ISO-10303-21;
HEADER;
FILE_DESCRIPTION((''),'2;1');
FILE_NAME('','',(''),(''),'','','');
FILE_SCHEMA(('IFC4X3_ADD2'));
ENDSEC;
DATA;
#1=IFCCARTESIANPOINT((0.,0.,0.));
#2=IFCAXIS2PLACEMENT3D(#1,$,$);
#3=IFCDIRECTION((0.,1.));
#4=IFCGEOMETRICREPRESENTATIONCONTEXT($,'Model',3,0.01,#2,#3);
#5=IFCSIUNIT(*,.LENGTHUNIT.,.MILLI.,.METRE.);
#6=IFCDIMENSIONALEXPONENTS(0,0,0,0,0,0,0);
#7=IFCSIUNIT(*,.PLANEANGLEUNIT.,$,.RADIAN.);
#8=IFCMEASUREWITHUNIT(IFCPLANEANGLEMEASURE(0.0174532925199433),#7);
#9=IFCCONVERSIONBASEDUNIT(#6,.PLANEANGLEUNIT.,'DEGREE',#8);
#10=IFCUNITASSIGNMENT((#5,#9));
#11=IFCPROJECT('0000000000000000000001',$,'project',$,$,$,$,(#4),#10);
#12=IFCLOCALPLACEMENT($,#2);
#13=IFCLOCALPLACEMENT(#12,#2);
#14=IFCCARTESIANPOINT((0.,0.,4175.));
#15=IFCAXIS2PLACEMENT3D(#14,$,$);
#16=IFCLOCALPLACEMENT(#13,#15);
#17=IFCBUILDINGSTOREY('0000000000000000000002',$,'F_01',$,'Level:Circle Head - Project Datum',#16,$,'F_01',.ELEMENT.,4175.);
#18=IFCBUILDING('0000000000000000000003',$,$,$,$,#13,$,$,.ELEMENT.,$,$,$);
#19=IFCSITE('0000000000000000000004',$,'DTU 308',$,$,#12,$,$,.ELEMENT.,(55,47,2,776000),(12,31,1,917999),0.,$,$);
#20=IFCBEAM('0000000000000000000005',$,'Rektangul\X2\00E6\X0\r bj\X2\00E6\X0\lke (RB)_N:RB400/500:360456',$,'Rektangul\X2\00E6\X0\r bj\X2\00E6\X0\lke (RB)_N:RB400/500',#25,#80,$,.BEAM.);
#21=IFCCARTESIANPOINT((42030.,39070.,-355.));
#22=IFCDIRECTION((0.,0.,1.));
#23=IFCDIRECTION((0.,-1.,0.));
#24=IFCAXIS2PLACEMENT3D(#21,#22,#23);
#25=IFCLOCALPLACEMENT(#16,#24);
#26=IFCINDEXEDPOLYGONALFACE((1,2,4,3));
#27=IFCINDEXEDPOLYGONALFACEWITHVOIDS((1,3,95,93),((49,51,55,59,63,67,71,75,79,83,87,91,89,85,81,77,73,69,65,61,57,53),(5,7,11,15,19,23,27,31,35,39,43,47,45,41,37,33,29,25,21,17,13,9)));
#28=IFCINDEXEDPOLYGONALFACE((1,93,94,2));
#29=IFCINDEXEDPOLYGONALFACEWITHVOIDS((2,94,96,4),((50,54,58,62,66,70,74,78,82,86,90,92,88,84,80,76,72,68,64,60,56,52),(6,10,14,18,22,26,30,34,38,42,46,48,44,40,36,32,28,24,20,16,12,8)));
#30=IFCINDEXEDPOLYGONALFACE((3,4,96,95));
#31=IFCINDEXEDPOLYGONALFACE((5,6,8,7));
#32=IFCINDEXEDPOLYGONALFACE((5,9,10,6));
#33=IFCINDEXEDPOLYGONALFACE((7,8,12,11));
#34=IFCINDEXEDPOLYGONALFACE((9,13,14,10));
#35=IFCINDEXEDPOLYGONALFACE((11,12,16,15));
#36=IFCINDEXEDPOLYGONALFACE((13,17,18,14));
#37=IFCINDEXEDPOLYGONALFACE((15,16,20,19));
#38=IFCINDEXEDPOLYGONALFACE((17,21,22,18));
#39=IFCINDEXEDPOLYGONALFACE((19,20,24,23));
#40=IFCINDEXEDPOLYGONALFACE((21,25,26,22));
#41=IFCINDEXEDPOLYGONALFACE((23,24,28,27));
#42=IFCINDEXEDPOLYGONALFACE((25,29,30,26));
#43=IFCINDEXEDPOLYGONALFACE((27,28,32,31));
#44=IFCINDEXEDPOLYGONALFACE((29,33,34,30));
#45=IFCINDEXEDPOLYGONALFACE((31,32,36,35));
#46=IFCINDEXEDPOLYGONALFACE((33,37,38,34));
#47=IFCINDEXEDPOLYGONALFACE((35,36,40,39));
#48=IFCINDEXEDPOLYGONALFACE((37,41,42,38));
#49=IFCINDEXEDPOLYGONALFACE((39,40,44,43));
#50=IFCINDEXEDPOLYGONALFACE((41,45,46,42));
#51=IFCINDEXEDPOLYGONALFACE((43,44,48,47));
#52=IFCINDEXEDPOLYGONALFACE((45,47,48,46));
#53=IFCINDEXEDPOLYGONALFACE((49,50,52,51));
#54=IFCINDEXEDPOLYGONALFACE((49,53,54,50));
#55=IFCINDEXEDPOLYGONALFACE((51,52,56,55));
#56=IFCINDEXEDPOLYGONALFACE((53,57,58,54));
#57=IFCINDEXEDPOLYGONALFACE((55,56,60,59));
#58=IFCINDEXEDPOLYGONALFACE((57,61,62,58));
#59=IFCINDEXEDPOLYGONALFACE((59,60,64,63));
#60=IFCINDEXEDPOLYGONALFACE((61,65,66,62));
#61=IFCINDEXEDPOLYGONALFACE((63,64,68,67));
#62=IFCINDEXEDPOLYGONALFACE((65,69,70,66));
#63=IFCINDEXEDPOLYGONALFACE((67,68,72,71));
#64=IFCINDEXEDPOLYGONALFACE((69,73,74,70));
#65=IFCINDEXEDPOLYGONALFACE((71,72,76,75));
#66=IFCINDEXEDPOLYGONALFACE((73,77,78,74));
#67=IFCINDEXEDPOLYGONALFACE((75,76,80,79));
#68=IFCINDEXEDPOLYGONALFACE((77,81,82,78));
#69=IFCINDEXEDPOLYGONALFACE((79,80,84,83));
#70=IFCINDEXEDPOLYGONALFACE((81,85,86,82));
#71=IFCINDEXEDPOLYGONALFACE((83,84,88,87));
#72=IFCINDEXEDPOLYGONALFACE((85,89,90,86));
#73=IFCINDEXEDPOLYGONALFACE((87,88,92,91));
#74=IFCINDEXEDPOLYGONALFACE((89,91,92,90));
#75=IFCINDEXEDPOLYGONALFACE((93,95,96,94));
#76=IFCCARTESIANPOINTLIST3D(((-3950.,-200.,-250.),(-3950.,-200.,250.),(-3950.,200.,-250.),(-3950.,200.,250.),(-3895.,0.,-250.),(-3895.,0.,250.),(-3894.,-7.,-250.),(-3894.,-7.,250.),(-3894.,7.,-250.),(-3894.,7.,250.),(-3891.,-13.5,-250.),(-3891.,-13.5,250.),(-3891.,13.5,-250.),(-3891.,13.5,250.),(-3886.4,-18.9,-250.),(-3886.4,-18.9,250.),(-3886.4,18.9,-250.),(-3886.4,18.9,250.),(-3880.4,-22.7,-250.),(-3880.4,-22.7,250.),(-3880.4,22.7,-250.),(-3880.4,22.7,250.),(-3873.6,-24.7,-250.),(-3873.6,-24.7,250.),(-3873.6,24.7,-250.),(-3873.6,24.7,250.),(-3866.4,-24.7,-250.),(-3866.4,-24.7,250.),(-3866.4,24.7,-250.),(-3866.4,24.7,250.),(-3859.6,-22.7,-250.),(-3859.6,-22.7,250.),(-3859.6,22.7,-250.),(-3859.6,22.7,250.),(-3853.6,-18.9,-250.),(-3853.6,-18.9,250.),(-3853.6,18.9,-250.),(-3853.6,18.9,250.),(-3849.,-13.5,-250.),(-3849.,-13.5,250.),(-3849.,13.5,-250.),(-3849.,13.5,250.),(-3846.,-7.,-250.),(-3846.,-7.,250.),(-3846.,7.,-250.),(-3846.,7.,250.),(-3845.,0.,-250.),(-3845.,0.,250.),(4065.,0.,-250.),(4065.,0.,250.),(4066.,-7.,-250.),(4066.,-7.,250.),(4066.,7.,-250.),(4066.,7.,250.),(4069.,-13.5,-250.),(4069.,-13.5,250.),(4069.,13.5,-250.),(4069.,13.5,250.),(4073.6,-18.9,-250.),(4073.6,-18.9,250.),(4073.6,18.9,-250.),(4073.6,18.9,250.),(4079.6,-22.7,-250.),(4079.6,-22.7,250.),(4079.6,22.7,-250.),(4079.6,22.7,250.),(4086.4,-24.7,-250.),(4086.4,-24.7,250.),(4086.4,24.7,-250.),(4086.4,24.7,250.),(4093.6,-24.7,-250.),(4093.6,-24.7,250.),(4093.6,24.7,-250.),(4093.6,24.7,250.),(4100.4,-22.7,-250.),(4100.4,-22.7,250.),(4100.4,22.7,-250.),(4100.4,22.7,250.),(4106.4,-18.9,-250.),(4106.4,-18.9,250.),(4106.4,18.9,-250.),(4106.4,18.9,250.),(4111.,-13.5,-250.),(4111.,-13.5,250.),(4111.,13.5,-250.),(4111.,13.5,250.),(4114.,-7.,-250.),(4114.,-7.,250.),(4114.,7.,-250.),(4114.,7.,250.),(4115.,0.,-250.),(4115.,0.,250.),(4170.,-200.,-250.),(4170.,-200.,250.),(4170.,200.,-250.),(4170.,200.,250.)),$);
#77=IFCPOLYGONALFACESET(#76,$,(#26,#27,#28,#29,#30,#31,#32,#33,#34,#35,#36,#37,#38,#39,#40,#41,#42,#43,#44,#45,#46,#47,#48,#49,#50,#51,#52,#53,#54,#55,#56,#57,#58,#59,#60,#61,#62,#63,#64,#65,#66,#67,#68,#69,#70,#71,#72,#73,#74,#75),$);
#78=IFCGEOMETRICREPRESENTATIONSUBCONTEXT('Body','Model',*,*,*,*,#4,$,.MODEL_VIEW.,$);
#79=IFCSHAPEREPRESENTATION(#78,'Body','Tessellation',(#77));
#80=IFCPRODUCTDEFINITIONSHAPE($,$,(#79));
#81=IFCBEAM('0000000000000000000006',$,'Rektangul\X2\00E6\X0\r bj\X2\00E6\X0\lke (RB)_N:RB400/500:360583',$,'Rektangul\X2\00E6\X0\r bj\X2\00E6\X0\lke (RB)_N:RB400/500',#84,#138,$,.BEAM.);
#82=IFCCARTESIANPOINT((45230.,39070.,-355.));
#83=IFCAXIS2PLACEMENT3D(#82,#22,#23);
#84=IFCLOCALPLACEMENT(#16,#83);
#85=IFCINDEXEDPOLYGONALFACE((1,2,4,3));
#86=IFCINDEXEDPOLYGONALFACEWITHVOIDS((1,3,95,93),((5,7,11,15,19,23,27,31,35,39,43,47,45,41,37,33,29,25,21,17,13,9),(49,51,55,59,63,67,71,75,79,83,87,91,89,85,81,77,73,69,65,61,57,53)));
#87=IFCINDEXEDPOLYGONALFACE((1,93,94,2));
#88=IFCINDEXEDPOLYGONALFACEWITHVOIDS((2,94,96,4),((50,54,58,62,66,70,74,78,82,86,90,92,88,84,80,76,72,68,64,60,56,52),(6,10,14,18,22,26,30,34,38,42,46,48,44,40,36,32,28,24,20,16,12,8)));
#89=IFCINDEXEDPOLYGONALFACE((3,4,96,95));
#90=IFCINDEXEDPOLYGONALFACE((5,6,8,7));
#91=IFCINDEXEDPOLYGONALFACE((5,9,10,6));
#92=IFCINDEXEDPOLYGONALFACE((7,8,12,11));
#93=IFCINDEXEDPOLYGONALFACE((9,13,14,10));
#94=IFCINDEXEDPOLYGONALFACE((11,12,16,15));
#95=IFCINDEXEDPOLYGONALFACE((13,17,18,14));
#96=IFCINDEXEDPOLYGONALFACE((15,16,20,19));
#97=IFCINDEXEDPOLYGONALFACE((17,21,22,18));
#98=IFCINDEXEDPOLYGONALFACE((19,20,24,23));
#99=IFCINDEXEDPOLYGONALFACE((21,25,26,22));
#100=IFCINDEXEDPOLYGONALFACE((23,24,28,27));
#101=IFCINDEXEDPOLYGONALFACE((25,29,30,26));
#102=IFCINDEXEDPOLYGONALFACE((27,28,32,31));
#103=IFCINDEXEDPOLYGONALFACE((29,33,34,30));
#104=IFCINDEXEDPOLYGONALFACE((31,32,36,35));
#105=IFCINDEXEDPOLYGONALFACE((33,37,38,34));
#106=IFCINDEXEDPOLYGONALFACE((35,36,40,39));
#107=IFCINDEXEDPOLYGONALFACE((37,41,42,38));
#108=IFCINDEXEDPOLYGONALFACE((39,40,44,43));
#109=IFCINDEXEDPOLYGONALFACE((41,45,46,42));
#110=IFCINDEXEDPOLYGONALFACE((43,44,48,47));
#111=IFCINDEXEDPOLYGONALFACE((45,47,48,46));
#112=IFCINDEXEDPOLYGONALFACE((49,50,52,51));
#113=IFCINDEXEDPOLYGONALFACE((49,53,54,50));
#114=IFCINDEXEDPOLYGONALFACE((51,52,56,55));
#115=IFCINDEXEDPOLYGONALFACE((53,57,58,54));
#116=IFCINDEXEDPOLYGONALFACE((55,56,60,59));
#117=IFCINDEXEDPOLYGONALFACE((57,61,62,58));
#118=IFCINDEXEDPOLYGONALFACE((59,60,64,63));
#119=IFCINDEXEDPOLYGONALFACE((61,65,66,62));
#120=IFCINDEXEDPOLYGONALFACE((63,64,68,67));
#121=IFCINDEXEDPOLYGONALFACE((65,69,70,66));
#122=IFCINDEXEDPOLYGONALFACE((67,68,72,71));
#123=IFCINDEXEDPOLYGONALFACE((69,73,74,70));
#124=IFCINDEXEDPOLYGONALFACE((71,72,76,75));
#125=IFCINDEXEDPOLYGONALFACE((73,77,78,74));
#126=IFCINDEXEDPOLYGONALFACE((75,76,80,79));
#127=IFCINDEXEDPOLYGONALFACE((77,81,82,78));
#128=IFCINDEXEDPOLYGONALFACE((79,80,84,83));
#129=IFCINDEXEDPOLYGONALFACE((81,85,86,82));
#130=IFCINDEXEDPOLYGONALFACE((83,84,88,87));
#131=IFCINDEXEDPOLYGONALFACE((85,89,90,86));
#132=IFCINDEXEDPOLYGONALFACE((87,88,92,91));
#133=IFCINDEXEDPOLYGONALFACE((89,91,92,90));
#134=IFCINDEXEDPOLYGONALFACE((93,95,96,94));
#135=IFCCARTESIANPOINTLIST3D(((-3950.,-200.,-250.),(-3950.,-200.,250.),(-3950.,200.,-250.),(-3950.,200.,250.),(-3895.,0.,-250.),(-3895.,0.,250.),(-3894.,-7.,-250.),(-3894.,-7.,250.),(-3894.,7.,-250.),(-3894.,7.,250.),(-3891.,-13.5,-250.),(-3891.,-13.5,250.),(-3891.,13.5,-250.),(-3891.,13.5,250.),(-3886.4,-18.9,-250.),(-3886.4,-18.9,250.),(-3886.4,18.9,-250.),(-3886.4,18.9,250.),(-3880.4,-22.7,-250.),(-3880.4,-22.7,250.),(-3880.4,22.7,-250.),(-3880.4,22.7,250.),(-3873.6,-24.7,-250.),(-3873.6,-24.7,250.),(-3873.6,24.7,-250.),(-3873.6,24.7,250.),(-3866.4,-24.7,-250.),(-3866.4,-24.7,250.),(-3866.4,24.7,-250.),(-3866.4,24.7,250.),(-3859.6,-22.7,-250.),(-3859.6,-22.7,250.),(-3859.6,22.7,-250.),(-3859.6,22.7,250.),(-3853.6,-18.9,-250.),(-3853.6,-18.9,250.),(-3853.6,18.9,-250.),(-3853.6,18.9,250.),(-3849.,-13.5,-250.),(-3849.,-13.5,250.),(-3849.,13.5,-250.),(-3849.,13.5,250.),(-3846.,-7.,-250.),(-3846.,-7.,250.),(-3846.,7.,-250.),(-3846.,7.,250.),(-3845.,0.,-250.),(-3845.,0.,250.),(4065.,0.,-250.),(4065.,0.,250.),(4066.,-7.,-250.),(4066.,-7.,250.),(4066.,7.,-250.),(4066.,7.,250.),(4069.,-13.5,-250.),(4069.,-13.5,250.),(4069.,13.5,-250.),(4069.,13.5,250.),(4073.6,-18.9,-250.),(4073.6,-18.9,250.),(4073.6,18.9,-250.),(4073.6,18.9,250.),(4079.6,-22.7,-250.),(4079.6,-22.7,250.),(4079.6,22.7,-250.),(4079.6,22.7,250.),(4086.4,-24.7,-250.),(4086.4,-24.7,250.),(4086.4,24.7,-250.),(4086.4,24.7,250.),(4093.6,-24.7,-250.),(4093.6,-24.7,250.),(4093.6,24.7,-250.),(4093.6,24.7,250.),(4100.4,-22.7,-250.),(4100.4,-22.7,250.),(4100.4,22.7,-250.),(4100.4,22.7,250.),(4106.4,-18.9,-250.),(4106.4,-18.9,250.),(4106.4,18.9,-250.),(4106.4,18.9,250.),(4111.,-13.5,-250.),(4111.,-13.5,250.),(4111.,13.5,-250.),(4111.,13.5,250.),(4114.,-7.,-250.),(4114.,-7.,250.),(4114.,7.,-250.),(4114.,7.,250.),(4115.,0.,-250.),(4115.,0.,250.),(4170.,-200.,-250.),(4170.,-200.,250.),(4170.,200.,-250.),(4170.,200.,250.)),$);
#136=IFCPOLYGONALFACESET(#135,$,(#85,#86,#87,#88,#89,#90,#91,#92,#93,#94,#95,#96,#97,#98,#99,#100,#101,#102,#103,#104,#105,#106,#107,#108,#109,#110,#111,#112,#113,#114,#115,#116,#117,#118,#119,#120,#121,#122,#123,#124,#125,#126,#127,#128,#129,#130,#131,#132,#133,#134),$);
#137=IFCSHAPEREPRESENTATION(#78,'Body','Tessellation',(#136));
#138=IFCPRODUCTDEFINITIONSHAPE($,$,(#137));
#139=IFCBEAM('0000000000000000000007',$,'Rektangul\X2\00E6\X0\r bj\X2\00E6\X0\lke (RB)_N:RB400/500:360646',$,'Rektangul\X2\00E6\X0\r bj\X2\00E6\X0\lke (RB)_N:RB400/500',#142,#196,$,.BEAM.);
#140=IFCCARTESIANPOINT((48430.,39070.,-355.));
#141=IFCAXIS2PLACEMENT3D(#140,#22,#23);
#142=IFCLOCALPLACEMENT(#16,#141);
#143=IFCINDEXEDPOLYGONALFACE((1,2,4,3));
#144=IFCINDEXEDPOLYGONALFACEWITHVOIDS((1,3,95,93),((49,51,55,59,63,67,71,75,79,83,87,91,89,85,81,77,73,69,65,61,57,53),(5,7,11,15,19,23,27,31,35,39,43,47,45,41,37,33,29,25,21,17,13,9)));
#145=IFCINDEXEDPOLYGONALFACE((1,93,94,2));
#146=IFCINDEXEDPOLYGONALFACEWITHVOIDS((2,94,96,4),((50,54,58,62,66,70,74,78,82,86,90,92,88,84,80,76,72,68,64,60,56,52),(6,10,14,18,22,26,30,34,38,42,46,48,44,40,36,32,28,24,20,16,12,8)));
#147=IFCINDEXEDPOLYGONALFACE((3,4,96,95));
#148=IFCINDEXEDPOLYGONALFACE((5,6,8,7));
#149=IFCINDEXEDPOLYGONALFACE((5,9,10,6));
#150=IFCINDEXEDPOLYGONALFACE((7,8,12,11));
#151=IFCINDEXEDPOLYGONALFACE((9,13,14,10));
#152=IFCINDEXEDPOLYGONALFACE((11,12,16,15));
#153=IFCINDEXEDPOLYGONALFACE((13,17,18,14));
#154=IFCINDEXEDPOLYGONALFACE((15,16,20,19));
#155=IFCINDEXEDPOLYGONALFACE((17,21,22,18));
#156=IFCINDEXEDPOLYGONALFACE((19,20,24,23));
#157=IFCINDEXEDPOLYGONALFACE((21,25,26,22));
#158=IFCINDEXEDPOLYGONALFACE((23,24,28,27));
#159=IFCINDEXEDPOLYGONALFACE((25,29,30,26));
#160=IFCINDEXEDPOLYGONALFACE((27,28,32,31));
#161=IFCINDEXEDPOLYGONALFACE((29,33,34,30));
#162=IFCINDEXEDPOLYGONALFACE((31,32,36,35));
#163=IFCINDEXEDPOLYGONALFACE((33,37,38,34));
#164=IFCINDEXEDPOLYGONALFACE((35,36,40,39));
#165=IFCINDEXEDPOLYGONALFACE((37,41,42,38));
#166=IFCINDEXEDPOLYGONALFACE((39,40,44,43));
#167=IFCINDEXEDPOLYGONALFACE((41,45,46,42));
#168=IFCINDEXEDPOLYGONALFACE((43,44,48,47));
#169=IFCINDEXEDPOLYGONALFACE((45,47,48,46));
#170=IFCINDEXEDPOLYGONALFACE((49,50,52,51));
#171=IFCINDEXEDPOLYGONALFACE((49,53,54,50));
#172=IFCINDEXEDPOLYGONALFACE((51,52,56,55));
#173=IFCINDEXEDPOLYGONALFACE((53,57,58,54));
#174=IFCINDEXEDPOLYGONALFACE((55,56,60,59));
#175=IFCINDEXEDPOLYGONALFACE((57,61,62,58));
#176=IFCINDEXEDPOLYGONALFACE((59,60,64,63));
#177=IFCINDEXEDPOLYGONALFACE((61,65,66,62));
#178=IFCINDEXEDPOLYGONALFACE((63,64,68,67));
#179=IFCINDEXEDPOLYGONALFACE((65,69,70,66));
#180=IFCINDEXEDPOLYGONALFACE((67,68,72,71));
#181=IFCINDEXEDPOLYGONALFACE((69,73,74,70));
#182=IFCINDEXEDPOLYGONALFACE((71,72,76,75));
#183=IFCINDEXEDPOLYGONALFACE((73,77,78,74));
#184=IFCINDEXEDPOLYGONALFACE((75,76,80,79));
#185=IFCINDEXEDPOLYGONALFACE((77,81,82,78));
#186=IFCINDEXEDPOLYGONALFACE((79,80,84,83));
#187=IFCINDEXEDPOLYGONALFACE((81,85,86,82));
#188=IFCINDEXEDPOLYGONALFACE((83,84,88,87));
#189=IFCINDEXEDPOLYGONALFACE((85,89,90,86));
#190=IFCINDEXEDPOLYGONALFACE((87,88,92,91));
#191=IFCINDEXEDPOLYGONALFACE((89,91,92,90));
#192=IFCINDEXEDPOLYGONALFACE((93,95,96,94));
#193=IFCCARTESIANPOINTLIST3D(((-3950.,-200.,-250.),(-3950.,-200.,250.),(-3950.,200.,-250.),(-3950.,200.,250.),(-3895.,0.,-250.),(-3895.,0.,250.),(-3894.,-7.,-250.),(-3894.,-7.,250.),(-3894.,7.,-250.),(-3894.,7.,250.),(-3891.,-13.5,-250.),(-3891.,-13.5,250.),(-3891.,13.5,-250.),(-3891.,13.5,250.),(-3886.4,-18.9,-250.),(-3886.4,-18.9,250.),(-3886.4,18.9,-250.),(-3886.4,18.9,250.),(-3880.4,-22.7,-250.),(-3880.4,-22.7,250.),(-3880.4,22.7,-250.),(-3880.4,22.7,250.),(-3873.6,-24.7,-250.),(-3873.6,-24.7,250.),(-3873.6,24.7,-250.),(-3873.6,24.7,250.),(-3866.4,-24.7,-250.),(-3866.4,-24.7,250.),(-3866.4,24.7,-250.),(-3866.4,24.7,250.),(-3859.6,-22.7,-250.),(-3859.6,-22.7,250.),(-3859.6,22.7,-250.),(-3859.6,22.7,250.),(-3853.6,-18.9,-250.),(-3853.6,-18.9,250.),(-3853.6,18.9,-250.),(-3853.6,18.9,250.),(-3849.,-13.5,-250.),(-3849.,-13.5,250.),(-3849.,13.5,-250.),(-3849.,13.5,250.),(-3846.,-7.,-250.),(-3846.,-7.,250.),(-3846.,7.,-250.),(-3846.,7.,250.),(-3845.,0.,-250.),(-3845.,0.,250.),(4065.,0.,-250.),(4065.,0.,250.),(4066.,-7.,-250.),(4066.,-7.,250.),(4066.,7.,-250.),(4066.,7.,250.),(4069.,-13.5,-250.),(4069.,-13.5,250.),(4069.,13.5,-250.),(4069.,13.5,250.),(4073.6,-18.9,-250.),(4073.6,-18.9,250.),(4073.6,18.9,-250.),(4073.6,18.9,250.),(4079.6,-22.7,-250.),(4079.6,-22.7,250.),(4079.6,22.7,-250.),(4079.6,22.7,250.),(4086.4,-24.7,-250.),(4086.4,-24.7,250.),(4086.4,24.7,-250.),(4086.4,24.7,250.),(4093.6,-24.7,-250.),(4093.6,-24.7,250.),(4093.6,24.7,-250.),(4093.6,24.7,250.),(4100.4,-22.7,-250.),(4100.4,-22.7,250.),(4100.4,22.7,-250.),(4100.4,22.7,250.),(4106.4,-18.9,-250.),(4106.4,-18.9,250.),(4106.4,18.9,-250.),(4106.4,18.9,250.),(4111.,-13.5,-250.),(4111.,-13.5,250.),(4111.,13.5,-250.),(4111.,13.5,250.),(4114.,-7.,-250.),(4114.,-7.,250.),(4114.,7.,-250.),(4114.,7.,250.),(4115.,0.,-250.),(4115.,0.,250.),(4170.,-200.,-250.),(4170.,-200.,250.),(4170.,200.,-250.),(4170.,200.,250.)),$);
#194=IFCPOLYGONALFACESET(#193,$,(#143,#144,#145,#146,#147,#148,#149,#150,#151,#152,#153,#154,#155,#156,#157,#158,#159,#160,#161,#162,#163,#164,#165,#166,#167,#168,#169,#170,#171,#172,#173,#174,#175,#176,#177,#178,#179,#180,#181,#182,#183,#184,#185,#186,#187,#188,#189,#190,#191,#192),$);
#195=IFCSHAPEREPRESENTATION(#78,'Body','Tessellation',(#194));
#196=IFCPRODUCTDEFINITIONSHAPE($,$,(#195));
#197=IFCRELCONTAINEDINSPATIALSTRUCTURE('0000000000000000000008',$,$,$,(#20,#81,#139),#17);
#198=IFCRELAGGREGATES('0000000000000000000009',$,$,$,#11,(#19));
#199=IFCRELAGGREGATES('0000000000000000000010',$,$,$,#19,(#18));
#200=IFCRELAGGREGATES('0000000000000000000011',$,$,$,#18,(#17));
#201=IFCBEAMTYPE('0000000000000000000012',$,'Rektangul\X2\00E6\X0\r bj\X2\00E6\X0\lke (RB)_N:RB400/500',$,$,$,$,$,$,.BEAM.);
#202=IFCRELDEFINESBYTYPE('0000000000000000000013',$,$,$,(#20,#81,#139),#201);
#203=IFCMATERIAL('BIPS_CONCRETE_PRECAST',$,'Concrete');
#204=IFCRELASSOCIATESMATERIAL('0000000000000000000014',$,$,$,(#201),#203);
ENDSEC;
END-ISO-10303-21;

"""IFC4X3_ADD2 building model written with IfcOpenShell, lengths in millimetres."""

from ifc_helpers import new_model, entity, si_unit, converted_unit, direction, frame, frame_2d, origin, place, context, subcontext, project, spatial, polyline, circle_curve, parameter, trimmed, segment, composite_curve, outline, extrude, source, transform, mapped, material, material_profile, profile_set, type_object, element, save


model = new_model("IFC4X3_ADD2")

# Units and contexts
model_context = context("Model", 3, precision=0.01, world=origin(), true_north=direction((0.0, 1.0)))
body_context = subcontext(model_context, "Body", "Model", "MODEL_VIEW")
ifc_project = project(units=[si_unit("LENGTHUNIT", "METRE", prefix="MILLI"), converted_unit("PLANEANGLEUNIT", "DEGREE", entity("IfcPlaneAngleMeasure", 0.0174532925199433), si_unit("PLANEANGLEUNIT", "RADIAN"), dimensions=[0, 0, 0, 0, 0, 0, 0])], contexts=[model_context])

# Site, building, storey
site_placement = place(None, origin())
site = spatial("IfcSite", under=ifc_project, at=site_placement, Name="DTU 308", CompositionType="ELEMENT", RefLatitude=(55, 47, 2, 776000), RefLongitude=(12, 31, 1, 917999), RefElevation=0.0)
building_placement = place(site_placement, origin())
building = spatial("IfcBuilding", under=site, at=building_placement, CompositionType="ELEMENT")
storey_placement = place(building_placement, frame((0.0, 0.0, 4175.0)))
storey = spatial("IfcBuildingStorey", under=building, at=storey_placement, Name="F_01", ObjectType="Level:Circle Head - Project Datum", LongName="F_01", CompositionType="ELEMENT", Elevation=4175.0)

# Beams
ifc_material_1 = material(Name="BIPS_CONCRETE_PRECAST", Category="Concrete")
ifc_material_profile_1 = material_profile(ifc_material_1, outline(polyline([(-4060.0, -200.0), (4060.0, -200.0), (4060.0, 200.0), (-4060.0, 200.0), (-4060.0, -200.0)]), holes=[composite_curve([segment(trimmed(circle_curve(frame_2d((3980.0, 0.0), x_axis=(-1.0, 0.0)), 25.0), [parameter(0.0)], [parameter(180.0)], True, "PARAMETER"), False, "CONTINUOUS"), segment(trimmed(circle_curve(frame_2d((3980.0, 0.0), x_axis=(-1.0, 0.0)), 25.0), [parameter(180.0)], [parameter(360.0)], True, "PARAMETER"), False, "CONTINUOUS")], self_intersect=False), composite_curve([segment(trimmed(circle_curve(frame_2d((-3980.0, 0.0), x_axis=(-1.0, 0.0)), 25.0), [parameter(0.0)], [parameter(180.0)], True, "PARAMETER"), False, "CONTINUOUS"), segment(trimmed(circle_curve(frame_2d((-3980.0, 0.0), x_axis=(-1.0, 0.0)), 25.0), [parameter(180.0)], [parameter(360.0)], True, "PARAMETER"), False, "CONTINUOUS")], self_intersect=False)]), Name="RB400/500")
ifc_profile_set_1 = profile_set([ifc_material_profile_1], Name="RB400/500")
beam_type_1 = type_object("IfcBeamType", Name="Rektangulær bjælke (RB)_N:RB400/500", PredefinedType="BEAM", material=ifc_profile_set_1)
shared_shape_1 = source(origin(), body_context, "Body", "SweptSolid", [
    extrude(outline(polyline([(-4060.0, -200.0), (4060.0, -200.0), (4060.0, 200.0), (-4060.0, 200.0), (-4060.0, -200.0)]), holes=[composite_curve([segment(trimmed(circle_curve(frame_2d((3980.0, 0.0), x_axis=(-1.0, 0.0)), 25.0), [parameter(0.0)], [parameter(180.0)], True, "PARAMETER"), False, "CONTINUOUS"), segment(trimmed(circle_curve(frame_2d((3980.0, 0.0), x_axis=(-1.0, 0.0)), 25.0), [parameter(180.0)], [parameter(360.0)], True, "PARAMETER"), False, "CONTINUOUS")], self_intersect=False), composite_curve([segment(trimmed(circle_curve(frame_2d((-3980.0, 0.0), x_axis=(-1.0, 0.0)), 25.0), [parameter(0.0)], [parameter(180.0)], True, "PARAMETER"), False, "CONTINUOUS"), segment(trimmed(circle_curve(frame_2d((-3980.0, 0.0), x_axis=(-1.0, 0.0)), 25.0), [parameter(180.0)], [parameter(360.0)], True, "PARAMETER"), False, "CONTINUOUS")], self_intersect=False)]), frame((110.0, 0.0, -250.0), z_axis=(0.0, 0.0, 1.0), x_axis=(-1.0, 0.0, 0.0)), (0.0, 0.0, 1.0), 500.0),
])
for number, where, z_axis, x_axis, name in (
    (1, (42030.0, 39070.0, -355.0), (0.0, 0.0, 1.0), (0.0, -1.0, 0.0), "Rektangulær bjælke (RB)_N:RB400/500:360456"),
    (2, (45230.0, 39070.0, -355.0), (0.0, 0.0, 1.0), (0.0, -1.0, 0.0), "Rektangulær bjælke (RB)_N:RB400/500:360583"),
    (3, (48430.0, 39070.0, -355.0), (0.0, 0.0, 1.0), (0.0, -1.0, 0.0), "Rektangulær bjælke (RB)_N:RB400/500:360646"),
):
    element("IfcBeam", number, at=place(storey_placement, frame(where, z_axis=z_axis, x_axis=x_axis)), inside=storey, type_object=beam_type_1, Name=name, ObjectType="Rektangulær bjælke (RB)_N:RB400/500", PredefinedType="BEAM", context=body_context, shape_type="MappedRepresentation", body=[
        mapped(shared_shape_1, transform((0.0, 0.0, 0.0), scale=1.0)),
    ])

save(model, "model.ifc")
